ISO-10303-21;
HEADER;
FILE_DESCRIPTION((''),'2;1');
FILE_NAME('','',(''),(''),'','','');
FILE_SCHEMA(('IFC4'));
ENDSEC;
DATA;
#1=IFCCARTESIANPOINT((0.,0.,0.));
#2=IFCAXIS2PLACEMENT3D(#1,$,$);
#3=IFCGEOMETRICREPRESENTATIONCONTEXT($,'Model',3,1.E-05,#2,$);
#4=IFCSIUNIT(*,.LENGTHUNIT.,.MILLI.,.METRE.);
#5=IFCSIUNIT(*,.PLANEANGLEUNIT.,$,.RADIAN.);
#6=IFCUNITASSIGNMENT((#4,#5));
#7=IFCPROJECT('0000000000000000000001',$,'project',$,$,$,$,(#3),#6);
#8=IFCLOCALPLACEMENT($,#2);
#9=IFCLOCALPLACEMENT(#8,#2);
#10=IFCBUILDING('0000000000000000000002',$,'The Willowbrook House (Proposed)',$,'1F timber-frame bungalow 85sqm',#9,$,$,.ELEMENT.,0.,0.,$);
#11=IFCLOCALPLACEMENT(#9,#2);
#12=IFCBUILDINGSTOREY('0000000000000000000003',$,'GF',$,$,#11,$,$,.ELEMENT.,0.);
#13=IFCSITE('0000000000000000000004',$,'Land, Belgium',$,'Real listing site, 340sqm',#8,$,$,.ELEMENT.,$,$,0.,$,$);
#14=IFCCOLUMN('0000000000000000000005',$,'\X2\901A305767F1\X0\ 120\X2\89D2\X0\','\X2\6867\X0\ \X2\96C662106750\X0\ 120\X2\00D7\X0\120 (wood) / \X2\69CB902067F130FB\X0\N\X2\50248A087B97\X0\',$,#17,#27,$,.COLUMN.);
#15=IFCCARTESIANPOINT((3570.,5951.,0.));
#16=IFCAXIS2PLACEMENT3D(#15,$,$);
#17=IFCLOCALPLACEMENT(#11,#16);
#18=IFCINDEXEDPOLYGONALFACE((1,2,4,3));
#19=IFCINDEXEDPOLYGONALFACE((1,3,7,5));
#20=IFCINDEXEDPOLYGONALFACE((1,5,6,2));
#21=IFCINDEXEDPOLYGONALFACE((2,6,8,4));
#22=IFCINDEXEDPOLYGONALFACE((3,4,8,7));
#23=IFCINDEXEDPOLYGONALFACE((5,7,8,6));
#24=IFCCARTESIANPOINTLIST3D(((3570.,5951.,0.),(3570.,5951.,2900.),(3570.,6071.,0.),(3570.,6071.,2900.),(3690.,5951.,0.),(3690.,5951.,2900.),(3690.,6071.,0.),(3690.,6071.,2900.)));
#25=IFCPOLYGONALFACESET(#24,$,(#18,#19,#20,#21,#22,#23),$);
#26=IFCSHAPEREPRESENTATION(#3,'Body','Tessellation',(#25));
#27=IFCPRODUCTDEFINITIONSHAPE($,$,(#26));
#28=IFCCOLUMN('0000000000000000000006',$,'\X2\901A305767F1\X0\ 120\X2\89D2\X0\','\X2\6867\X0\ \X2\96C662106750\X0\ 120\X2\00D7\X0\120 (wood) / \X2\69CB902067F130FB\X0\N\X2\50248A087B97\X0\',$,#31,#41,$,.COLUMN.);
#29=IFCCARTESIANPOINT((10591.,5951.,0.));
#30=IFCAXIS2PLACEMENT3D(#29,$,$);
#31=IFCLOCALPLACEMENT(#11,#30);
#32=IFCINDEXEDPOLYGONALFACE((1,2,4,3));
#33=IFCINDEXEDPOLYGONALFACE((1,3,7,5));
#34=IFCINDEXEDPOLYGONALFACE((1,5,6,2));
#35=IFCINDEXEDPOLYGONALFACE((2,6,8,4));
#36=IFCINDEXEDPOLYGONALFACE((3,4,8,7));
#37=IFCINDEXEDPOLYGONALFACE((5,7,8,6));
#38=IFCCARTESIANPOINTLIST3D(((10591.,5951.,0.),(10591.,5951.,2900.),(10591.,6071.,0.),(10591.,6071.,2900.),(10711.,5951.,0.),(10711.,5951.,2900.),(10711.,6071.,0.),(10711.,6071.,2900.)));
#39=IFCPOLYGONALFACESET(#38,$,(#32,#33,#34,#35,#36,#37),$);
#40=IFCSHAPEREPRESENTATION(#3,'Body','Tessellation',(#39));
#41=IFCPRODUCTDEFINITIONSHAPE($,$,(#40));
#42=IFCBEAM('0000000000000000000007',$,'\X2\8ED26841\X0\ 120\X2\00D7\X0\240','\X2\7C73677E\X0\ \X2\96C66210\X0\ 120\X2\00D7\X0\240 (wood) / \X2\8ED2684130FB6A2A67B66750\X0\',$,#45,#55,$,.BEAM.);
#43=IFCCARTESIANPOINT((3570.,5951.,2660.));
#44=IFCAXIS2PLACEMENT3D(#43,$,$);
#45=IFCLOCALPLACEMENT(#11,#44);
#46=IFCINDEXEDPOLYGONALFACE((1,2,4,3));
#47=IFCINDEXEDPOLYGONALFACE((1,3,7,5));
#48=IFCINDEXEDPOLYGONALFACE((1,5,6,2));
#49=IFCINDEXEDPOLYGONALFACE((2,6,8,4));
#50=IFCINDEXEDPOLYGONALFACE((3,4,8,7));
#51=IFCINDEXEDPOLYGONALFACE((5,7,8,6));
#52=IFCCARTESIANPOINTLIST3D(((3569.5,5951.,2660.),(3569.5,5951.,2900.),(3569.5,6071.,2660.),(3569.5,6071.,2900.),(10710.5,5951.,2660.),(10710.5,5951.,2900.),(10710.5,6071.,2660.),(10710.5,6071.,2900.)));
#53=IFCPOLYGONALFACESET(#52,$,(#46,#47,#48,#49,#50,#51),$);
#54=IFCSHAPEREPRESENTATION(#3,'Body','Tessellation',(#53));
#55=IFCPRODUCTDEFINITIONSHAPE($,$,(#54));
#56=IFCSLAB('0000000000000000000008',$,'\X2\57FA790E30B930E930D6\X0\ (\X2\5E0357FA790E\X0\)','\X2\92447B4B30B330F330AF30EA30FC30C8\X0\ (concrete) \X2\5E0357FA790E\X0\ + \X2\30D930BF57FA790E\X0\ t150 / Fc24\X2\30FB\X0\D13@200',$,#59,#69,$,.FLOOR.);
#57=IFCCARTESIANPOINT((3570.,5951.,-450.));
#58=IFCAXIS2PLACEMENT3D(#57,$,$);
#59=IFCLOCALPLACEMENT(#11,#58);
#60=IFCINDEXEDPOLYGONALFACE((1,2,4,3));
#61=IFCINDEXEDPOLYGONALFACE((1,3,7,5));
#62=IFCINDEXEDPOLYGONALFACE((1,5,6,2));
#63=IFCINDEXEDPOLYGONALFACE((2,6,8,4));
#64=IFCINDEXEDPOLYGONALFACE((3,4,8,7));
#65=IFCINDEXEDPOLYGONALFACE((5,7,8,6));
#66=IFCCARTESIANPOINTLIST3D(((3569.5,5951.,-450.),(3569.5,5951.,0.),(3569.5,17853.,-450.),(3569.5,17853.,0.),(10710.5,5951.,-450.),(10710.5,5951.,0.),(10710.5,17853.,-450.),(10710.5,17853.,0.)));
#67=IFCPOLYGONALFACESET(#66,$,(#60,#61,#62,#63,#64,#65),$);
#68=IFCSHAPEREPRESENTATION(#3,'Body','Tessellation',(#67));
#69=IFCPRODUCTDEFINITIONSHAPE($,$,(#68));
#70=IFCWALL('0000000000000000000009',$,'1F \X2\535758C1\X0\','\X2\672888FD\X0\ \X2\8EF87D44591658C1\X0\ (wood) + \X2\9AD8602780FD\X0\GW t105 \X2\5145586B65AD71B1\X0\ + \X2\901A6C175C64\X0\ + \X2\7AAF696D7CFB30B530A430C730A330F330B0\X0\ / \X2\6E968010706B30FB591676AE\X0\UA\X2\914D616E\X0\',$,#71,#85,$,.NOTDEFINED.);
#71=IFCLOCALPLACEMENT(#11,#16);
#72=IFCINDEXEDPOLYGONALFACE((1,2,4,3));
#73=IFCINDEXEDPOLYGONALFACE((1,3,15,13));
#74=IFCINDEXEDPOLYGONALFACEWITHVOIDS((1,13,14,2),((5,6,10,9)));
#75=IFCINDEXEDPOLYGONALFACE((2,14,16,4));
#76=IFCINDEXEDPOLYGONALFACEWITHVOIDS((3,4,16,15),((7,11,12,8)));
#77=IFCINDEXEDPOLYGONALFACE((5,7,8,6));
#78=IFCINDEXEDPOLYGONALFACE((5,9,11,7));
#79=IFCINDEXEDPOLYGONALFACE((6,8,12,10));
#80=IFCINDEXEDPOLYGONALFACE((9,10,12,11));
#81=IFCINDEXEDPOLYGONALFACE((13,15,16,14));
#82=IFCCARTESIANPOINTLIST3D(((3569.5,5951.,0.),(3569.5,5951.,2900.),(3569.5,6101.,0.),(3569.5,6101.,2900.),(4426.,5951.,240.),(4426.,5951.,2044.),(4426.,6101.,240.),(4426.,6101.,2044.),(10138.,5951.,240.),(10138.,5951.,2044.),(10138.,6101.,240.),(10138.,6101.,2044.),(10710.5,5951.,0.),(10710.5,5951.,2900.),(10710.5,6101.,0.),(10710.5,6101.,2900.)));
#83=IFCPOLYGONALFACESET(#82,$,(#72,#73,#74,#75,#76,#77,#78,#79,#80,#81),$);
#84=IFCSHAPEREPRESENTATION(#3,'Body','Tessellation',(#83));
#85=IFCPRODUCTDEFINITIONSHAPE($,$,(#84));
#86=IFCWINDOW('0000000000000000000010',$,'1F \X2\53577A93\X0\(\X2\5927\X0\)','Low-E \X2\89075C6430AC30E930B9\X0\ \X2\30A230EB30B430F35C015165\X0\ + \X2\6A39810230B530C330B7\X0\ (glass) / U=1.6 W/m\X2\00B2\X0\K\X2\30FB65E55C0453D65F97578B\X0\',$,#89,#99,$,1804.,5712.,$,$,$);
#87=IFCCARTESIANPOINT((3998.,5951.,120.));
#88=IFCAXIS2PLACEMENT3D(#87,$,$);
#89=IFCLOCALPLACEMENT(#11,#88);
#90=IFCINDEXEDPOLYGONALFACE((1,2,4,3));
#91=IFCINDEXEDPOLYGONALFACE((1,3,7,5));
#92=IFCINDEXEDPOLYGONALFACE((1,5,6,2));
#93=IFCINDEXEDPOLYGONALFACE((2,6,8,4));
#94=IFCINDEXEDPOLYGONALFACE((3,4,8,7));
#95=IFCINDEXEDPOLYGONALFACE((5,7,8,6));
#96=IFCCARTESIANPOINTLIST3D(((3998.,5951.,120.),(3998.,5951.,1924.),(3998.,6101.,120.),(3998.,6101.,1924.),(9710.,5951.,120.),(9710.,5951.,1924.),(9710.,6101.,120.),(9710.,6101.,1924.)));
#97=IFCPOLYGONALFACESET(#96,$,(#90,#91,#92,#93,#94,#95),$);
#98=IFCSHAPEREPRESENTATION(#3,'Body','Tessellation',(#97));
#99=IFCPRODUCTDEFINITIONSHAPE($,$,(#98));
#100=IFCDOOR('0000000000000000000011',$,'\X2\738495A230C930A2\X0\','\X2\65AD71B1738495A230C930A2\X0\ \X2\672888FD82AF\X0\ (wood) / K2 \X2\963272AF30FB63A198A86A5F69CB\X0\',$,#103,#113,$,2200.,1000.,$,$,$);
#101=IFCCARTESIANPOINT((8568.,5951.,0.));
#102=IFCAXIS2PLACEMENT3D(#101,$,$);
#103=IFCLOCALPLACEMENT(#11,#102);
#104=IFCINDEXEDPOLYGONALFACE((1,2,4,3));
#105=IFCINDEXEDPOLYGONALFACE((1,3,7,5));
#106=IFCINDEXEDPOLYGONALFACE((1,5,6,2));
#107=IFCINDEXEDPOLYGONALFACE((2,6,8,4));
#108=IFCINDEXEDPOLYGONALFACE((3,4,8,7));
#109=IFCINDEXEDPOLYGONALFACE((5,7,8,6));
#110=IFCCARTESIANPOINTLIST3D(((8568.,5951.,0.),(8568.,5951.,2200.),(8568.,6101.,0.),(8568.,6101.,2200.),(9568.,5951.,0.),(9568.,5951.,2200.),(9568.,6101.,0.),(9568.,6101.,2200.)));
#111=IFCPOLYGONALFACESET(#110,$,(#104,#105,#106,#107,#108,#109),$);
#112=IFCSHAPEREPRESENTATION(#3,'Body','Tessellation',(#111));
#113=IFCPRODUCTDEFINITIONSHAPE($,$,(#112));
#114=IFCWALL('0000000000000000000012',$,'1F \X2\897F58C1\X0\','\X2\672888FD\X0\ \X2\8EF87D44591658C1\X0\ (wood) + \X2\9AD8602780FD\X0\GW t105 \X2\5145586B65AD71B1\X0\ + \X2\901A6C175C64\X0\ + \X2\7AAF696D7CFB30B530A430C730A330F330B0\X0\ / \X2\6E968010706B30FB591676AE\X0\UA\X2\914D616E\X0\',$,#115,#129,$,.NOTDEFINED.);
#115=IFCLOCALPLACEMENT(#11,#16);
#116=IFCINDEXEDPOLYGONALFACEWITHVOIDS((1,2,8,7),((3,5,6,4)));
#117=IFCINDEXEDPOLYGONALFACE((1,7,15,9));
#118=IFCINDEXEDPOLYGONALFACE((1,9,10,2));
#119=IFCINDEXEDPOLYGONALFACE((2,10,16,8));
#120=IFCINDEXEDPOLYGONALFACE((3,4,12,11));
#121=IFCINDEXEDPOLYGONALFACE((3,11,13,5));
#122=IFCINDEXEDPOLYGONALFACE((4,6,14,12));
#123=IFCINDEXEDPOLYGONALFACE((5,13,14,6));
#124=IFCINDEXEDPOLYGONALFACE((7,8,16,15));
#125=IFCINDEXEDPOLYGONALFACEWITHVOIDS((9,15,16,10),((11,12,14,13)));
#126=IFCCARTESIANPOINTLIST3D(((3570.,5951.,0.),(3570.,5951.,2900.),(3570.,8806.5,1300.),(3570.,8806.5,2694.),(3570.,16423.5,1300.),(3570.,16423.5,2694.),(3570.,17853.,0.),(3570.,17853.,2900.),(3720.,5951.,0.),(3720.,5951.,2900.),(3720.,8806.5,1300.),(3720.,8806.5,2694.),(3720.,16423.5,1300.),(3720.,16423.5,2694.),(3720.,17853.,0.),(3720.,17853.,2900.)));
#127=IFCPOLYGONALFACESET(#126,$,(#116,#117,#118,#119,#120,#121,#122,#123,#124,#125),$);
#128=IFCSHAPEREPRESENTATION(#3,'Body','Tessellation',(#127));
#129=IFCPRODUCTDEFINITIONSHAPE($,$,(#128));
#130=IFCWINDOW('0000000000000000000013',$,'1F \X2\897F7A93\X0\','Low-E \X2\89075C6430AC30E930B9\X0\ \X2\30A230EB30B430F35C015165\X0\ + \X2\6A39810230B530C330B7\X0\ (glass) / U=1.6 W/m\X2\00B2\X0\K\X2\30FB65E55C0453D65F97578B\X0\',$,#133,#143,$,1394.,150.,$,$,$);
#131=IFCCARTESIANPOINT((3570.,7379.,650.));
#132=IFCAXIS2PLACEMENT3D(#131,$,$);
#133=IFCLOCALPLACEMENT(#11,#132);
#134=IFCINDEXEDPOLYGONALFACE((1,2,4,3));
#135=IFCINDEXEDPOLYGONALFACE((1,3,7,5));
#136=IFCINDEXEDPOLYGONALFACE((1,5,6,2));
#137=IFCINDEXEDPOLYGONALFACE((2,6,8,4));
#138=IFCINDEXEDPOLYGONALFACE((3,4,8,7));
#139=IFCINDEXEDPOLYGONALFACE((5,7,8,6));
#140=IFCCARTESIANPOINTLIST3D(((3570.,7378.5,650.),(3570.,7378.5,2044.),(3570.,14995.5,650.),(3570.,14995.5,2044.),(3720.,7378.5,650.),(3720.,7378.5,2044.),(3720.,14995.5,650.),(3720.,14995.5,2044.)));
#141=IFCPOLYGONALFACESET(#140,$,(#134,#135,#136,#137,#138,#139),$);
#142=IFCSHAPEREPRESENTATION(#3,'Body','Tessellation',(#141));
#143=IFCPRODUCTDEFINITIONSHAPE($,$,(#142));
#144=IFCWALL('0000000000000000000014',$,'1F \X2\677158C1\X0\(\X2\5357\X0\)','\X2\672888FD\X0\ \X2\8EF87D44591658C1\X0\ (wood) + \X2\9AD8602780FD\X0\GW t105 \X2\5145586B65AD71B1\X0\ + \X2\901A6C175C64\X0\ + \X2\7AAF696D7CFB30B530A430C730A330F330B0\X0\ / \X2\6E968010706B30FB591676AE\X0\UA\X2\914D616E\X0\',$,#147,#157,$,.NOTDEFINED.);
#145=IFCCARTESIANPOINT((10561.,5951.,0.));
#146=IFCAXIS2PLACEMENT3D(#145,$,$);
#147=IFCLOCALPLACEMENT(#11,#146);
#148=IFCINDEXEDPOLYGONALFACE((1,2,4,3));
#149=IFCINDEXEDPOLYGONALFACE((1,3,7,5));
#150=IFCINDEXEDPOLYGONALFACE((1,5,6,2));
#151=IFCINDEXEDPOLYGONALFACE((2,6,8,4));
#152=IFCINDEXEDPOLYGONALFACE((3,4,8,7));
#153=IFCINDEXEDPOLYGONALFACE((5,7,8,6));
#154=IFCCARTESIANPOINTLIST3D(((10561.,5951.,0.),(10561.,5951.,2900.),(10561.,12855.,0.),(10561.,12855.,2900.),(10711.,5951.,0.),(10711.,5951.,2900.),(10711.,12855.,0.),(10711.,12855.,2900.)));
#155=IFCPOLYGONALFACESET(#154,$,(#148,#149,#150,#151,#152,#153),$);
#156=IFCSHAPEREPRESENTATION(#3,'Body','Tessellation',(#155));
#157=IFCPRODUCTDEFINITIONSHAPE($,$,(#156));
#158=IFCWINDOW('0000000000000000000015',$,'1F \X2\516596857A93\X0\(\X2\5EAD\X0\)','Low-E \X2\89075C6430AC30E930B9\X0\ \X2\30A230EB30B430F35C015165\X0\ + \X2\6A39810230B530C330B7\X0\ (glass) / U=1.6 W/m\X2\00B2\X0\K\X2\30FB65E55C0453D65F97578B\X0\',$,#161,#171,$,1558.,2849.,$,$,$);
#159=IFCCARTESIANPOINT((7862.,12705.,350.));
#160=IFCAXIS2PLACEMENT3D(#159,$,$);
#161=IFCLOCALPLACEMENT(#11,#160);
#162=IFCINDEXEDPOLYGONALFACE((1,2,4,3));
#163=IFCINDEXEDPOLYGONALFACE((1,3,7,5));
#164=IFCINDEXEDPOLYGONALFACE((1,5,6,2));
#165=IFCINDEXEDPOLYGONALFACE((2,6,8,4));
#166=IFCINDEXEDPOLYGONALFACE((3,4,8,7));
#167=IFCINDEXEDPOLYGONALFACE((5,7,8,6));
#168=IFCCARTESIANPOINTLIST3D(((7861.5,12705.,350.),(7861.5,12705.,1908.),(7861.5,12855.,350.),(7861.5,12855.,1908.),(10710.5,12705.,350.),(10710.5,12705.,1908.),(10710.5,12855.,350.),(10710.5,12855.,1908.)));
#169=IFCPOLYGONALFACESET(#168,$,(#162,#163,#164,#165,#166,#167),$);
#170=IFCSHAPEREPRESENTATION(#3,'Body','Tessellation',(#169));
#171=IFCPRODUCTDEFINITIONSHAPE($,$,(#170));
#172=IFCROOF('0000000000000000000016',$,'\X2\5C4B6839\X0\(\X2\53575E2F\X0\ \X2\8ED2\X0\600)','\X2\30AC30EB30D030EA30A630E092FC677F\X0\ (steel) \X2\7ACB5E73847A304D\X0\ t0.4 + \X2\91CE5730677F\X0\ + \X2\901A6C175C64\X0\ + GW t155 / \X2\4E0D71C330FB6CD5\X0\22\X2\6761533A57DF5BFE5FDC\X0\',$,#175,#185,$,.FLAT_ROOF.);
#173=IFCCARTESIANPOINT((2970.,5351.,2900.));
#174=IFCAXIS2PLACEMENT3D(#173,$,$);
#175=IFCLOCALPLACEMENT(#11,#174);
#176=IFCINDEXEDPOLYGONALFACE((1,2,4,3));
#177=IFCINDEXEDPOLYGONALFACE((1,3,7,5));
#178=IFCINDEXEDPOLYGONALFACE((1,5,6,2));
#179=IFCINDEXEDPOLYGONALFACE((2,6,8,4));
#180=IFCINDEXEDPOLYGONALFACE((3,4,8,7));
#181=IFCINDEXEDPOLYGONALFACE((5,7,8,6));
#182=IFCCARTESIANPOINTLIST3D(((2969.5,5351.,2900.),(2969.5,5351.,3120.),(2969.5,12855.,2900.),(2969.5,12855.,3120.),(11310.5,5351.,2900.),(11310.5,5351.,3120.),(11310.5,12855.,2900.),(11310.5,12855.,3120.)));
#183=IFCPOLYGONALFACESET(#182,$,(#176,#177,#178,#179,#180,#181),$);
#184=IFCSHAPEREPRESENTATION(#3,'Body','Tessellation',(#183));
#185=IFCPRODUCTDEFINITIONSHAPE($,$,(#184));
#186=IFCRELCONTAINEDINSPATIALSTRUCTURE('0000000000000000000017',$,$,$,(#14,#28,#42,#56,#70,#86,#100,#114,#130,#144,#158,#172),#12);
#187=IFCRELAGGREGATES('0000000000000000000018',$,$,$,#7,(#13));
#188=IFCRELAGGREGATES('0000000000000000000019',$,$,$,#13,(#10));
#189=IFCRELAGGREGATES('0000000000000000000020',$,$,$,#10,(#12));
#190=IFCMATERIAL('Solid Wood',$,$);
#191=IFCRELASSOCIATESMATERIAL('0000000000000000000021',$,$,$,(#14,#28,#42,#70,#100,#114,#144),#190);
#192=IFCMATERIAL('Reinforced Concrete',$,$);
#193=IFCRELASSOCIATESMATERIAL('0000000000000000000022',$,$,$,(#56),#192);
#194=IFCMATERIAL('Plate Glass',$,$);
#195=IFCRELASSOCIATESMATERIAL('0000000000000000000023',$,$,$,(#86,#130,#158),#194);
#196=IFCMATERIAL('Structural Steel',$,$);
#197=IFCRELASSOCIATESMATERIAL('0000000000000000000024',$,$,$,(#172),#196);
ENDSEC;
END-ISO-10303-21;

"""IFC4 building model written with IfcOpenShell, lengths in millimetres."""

from ifc_helpers import new_model, si_unit, frame, frame_2d, origin, place, context, project, spatial, rectangle, extrude, material, element, fill, save


model = new_model("IFC4")

# Units and contexts
model_context = context("Model", 3, precision=1e-05, world=origin())
ifc_project = project(units=[si_unit("LENGTHUNIT", "METRE", prefix="MILLI"), si_unit("PLANEANGLEUNIT", "RADIAN")], contexts=[model_context])

# Site, building, storey
site_placement = place(None, origin())
site = spatial("IfcSite", under=ifc_project, at=site_placement, Name="Land, Belgium", ObjectType="Real listing site, 340sqm", CompositionType="ELEMENT", RefElevation=0.0)
building_placement = place(site_placement, origin())
building = spatial("IfcBuilding", under=site, at=building_placement, Name="The Willowbrook House (Proposed)", ObjectType="1F timber-frame bungalow 85sqm", CompositionType="ELEMENT", ElevationOfRefHeight=0.0, ElevationOfTerrain=0.0)
storey_placement = place(building_placement, origin())
storey = spatial("IfcBuildingStorey", under=building, at=storey_placement, Name="GF", CompositionType="ELEMENT", Elevation=0.0)

# Columns
ifc_material_1 = material(Name="Solid Wood")
column_1_placement = place(storey_placement, frame((3570.0, 5951.0, 0.0)))
element("IfcColumn", 1, at=column_1_placement, inside=storey, material=ifc_material_1, Name="通し柱 120角", Description="桧 集成材 120×120 (wood) / 構造柱・N値計算", PredefinedType="COLUMN", context=model_context, shape_type="SweptSolid", body=[
    extrude(rectangle(XDim=120.0, YDim=120.0, at=frame_2d((60.0, 60.0))), frame((3570.0, 5951.0, 0.0)), (0.0, 0.0, 1.0), 2900.0),
])
column_2_placement = place(storey_placement, frame((10591.0, 5951.0, 0.0)))
element("IfcColumn", 2, at=column_2_placement, inside=storey, material=ifc_material_1, Name="通し柱 120角", Description="桧 集成材 120×120 (wood) / 構造柱・N値計算", PredefinedType="COLUMN", context=model_context, shape_type="SweptSolid", body=[
    extrude(rectangle(XDim=120.0, YDim=120.0, at=frame_2d((60.0, 60.0))), frame((10591.0, 5951.0, 0.0)), (0.0, 0.0, 1.0), 2900.0),
])

# Beam
beam_1_placement = place(storey_placement, frame((3570.0, 5951.0, 2660.0)))
element("IfcBeam", 3, at=beam_1_placement, inside=storey, material=ifc_material_1, Name="軒桁 120×240", Description="米松 集成 120×240 (wood) / 軒桁・横架材", PredefinedType="BEAM", context=model_context, shape_type="SweptSolid", body=[
    extrude(rectangle(XDim=7141.0, YDim=120.0, at=frame_2d((3570.0, 60.0))), frame((3570.0, 5951.0, 2660.0)), (0.0, 0.0, 1.0), 240.0),
])

# Slab
ifc_material_2 = material(Name="Reinforced Concrete")
slab_1_placement = place(storey_placement, frame((3570.0, 5951.0, -450.0)))
element("IfcSlab", 4, at=slab_1_placement, inside=storey, material=ifc_material_2, Name="基礎スラブ (布基礎)", Description="鉄筋コンクリート (concrete) 布基礎 + ベタ基礎 t150 / Fc24・D13@200", PredefinedType="FLOOR", context=model_context, shape_type="SweptSolid", body=[
    extrude(rectangle(XDim=7141.0, YDim=11902.0, at=frame_2d((3570.0, 5951.0))), frame((3570.0, 5951.0, -450.0)), (0.0, 0.0, 1.0), 450.0),
])

# Wall, openings, window, door
wall_1_placement = place(storey_placement, frame((3570.0, 5951.0, 0.0)))
wall_1 = element("IfcWall", 5, at=wall_1_placement, inside=storey, material=ifc_material_1, Name="1F 南壁", Description="木製 軸組外壁 (wood) + 高性能GW t105 充填断熱 + 通気層 + 窯業系サイディング / 準耐火・外皮UA配慮", PredefinedType="NOTDEFINED", context=model_context, shape_type="SweptSolid", body=[
    extrude(rectangle(XDim=7141.0, YDim=150.0, at=frame_2d((3570.0, 75.0))), frame((3570.0, 5951.0, 0.0)), (0.0, 0.0, 1.0), 2900.0),
])
opening_1_placement = place(storey_placement, frame((3998.0, 5951.0, 120.0)))
opening_1 = element("IfcOpeningElement", 6, at=opening_1_placement, cuts=wall_1, PredefinedType="NOTDEFINED", context=model_context, shape_type="SweptSolid", body=[
    extrude(rectangle(XDim=5712.0, YDim=150.0, at=frame_2d((2856.0, 75.0))), frame((3998.0, 5951.0, 120.0)), (0.0, 0.0, 1.0), 1804.0),
])
opening_2_placement = place(storey_placement, frame((8568.0, 5951.0, 0.0)))
opening_2 = element("IfcOpeningElement", 7, at=opening_2_placement, cuts=wall_1, PredefinedType="NOTDEFINED", context=model_context, shape_type="SweptSolid", body=[
    extrude(rectangle(XDim=1000.0, YDim=150.0, at=frame_2d((500.0, 75.0))), frame((8568.0, 5951.0, 0.0)), (0.0, 0.0, 1.0), 2200.0),
])
ifc_material_3 = material(Name="Plate Glass")
window_1_placement = place(storey_placement, frame((3998.0, 5951.0, 120.0)))
window_1 = element("IfcWindow", 8, at=window_1_placement, inside=storey, material=ifc_material_3, Name="1F 南窓(大)", Description="Low-E 複層ガラス アルゴン封入 + 樹脂サッシ (glass) / U=1.6 W/m²K・日射取得型", OverallHeight=1804.0, OverallWidth=5712.0, context=model_context, shape_type="SweptSolid", body=[
    extrude(rectangle(XDim=5712.0, YDim=150.0, at=frame_2d((2856.0, 75.0))), frame((3998.0, 5951.0, 120.0)), (0.0, 0.0, 1.0), 1804.0),
])
fill(opening_1, window_1)
door_1_placement = place(storey_placement, frame((8568.0, 5951.0, 0.0)))
door_1 = element("IfcDoor", 9, at=door_1_placement, inside=storey, material=ifc_material_1, Name="玄関ドア", Description="断熱玄関ドア 木製芯 (wood) / K2 防犯・採風機構", OverallHeight=2200.0, OverallWidth=1000.0, context=model_context, shape_type="SweptSolid", body=[
    extrude(rectangle(XDim=1000.0, YDim=150.0, at=frame_2d((500.0, 75.0))), frame((8568.0, 5951.0, 0.0)), (0.0, 0.0, 1.0), 2200.0),
])
fill(opening_2, door_1)

# Walls, openings, windows
wall_2_placement = place(storey_placement, frame((3570.0, 5951.0, 0.0)))
wall_2 = element("IfcWall", 10, at=wall_2_placement, inside=storey, material=ifc_material_1, Name="1F 西壁", Description="木製 軸組外壁 (wood) + 高性能GW t105 充填断熱 + 通気層 + 窯業系サイディング / 準耐火・外皮UA配慮", PredefinedType="NOTDEFINED", context=model_context, shape_type="SweptSolid", body=[
    extrude(rectangle(XDim=150.0, YDim=11902.0, at=frame_2d((75.0, 5951.0))), frame((3570.0, 5951.0, 0.0)), (0.0, 0.0, 1.0), 2900.0),
])
opening_3_placement = place(storey_placement, frame((3570.0, 7379.0, 650.0)))
opening_3 = element("IfcOpeningElement", 11, at=opening_3_placement, cuts=wall_2, PredefinedType="NOTDEFINED", context=model_context, shape_type="SweptSolid", body=[
    extrude(rectangle(XDim=150.0, YDim=7617.0, at=frame_2d((75.0, 3808.0))), frame((3570.0, 7379.0, 650.0)), (0.0, 0.0, 1.0), 1394.0),
])
window_2_placement = place(storey_placement, frame((3570.0, 7379.0, 650.0)))
window_2 = element("IfcWindow", 12, at=window_2_placement, inside=storey, material=ifc_material_3, Name="1F 西窓", Description="Low-E 複層ガラス アルゴン封入 + 樹脂サッシ (glass) / U=1.6 W/m²K・日射取得型", OverallHeight=1394.0, OverallWidth=150.0, context=model_context, shape_type="SweptSolid", body=[
    extrude(rectangle(XDim=150.0, YDim=7617.0, at=frame_2d((75.0, 3808.0))), frame((3570.0, 7379.0, 650.0)), (0.0, 0.0, 1.0), 1394.0),
])
fill(opening_3, window_2)
wall_3_placement = place(storey_placement, frame((10561.0, 5951.0, 0.0)))
wall_3 = element("IfcWall", 13, at=wall_3_placement, inside=storey, material=ifc_material_1, Name="1F 東壁(南)", Description="木製 軸組外壁 (wood) + 高性能GW t105 充填断熱 + 通気層 + 窯業系サイディング / 準耐火・外皮UA配慮", PredefinedType="NOTDEFINED", context=model_context, shape_type="SweptSolid", body=[
    extrude(rectangle(XDim=150.0, YDim=6904.0, at=frame_2d((75.0, 3452.0))), frame((10561.0, 5951.0, 0.0)), (0.0, 0.0, 1.0), 2900.0),
])
opening_4_placement = place(storey_placement, frame((7862.0, 12705.0, 350.0)))
opening_4 = element("IfcOpeningElement", 14, at=opening_4_placement, cuts=wall_3, PredefinedType="NOTDEFINED", context=model_context, shape_type="SweptSolid", body=[
    extrude(rectangle(XDim=2849.0, YDim=150.0, at=frame_2d((1424.0, 75.0))), frame((7862.0, 12705.0, 350.0)), (0.0, 0.0, 1.0), 1558.0),
])
window_3_placement = place(storey_placement, frame((7862.0, 12705.0, 350.0)))
window_3 = element("IfcWindow", 15, at=window_3_placement, inside=storey, material=ifc_material_3, Name="1F 入隅窓(庭)", Description="Low-E 複層ガラス アルゴン封入 + 樹脂サッシ (glass) / U=1.6 W/m²K・日射取得型", OverallHeight=1558.0, OverallWidth=2849.0, context=model_context, shape_type="SweptSolid", body=[
    extrude(rectangle(XDim=2849.0, YDim=150.0, at=frame_2d((1424.0, 75.0))), frame((7862.0, 12705.0, 350.0)), (0.0, 0.0, 1.0), 1558.0),
])
fill(opening_4, window_3)

# Roof
ifc_material_4 = material(Name="Structural Steel")
roof_placement = place(storey_placement, frame((2970.0, 5351.0, 2900.0)))
element("IfcRoof", 16, at=roof_placement, inside=storey, material=ifc_material_4, Name="屋根(南帯 軒600)", Description="ガルバリウム鋼板 (steel) 立平葺き t0.4 + 野地板 + 通気層 + GW t155 / 不燃・法22条区域対応", PredefinedType="FLAT_ROOF", context=model_context, shape_type="SweptSolid", body=[
    extrude(rectangle(XDim=8341.0, YDim=7504.0, at=frame_2d((4170.0, 3752.0))), frame((2970.0, 5351.0, 2900.0)), (0.0, 0.0, 1.0), 220.0),
])

save(model, "model.ifc")
